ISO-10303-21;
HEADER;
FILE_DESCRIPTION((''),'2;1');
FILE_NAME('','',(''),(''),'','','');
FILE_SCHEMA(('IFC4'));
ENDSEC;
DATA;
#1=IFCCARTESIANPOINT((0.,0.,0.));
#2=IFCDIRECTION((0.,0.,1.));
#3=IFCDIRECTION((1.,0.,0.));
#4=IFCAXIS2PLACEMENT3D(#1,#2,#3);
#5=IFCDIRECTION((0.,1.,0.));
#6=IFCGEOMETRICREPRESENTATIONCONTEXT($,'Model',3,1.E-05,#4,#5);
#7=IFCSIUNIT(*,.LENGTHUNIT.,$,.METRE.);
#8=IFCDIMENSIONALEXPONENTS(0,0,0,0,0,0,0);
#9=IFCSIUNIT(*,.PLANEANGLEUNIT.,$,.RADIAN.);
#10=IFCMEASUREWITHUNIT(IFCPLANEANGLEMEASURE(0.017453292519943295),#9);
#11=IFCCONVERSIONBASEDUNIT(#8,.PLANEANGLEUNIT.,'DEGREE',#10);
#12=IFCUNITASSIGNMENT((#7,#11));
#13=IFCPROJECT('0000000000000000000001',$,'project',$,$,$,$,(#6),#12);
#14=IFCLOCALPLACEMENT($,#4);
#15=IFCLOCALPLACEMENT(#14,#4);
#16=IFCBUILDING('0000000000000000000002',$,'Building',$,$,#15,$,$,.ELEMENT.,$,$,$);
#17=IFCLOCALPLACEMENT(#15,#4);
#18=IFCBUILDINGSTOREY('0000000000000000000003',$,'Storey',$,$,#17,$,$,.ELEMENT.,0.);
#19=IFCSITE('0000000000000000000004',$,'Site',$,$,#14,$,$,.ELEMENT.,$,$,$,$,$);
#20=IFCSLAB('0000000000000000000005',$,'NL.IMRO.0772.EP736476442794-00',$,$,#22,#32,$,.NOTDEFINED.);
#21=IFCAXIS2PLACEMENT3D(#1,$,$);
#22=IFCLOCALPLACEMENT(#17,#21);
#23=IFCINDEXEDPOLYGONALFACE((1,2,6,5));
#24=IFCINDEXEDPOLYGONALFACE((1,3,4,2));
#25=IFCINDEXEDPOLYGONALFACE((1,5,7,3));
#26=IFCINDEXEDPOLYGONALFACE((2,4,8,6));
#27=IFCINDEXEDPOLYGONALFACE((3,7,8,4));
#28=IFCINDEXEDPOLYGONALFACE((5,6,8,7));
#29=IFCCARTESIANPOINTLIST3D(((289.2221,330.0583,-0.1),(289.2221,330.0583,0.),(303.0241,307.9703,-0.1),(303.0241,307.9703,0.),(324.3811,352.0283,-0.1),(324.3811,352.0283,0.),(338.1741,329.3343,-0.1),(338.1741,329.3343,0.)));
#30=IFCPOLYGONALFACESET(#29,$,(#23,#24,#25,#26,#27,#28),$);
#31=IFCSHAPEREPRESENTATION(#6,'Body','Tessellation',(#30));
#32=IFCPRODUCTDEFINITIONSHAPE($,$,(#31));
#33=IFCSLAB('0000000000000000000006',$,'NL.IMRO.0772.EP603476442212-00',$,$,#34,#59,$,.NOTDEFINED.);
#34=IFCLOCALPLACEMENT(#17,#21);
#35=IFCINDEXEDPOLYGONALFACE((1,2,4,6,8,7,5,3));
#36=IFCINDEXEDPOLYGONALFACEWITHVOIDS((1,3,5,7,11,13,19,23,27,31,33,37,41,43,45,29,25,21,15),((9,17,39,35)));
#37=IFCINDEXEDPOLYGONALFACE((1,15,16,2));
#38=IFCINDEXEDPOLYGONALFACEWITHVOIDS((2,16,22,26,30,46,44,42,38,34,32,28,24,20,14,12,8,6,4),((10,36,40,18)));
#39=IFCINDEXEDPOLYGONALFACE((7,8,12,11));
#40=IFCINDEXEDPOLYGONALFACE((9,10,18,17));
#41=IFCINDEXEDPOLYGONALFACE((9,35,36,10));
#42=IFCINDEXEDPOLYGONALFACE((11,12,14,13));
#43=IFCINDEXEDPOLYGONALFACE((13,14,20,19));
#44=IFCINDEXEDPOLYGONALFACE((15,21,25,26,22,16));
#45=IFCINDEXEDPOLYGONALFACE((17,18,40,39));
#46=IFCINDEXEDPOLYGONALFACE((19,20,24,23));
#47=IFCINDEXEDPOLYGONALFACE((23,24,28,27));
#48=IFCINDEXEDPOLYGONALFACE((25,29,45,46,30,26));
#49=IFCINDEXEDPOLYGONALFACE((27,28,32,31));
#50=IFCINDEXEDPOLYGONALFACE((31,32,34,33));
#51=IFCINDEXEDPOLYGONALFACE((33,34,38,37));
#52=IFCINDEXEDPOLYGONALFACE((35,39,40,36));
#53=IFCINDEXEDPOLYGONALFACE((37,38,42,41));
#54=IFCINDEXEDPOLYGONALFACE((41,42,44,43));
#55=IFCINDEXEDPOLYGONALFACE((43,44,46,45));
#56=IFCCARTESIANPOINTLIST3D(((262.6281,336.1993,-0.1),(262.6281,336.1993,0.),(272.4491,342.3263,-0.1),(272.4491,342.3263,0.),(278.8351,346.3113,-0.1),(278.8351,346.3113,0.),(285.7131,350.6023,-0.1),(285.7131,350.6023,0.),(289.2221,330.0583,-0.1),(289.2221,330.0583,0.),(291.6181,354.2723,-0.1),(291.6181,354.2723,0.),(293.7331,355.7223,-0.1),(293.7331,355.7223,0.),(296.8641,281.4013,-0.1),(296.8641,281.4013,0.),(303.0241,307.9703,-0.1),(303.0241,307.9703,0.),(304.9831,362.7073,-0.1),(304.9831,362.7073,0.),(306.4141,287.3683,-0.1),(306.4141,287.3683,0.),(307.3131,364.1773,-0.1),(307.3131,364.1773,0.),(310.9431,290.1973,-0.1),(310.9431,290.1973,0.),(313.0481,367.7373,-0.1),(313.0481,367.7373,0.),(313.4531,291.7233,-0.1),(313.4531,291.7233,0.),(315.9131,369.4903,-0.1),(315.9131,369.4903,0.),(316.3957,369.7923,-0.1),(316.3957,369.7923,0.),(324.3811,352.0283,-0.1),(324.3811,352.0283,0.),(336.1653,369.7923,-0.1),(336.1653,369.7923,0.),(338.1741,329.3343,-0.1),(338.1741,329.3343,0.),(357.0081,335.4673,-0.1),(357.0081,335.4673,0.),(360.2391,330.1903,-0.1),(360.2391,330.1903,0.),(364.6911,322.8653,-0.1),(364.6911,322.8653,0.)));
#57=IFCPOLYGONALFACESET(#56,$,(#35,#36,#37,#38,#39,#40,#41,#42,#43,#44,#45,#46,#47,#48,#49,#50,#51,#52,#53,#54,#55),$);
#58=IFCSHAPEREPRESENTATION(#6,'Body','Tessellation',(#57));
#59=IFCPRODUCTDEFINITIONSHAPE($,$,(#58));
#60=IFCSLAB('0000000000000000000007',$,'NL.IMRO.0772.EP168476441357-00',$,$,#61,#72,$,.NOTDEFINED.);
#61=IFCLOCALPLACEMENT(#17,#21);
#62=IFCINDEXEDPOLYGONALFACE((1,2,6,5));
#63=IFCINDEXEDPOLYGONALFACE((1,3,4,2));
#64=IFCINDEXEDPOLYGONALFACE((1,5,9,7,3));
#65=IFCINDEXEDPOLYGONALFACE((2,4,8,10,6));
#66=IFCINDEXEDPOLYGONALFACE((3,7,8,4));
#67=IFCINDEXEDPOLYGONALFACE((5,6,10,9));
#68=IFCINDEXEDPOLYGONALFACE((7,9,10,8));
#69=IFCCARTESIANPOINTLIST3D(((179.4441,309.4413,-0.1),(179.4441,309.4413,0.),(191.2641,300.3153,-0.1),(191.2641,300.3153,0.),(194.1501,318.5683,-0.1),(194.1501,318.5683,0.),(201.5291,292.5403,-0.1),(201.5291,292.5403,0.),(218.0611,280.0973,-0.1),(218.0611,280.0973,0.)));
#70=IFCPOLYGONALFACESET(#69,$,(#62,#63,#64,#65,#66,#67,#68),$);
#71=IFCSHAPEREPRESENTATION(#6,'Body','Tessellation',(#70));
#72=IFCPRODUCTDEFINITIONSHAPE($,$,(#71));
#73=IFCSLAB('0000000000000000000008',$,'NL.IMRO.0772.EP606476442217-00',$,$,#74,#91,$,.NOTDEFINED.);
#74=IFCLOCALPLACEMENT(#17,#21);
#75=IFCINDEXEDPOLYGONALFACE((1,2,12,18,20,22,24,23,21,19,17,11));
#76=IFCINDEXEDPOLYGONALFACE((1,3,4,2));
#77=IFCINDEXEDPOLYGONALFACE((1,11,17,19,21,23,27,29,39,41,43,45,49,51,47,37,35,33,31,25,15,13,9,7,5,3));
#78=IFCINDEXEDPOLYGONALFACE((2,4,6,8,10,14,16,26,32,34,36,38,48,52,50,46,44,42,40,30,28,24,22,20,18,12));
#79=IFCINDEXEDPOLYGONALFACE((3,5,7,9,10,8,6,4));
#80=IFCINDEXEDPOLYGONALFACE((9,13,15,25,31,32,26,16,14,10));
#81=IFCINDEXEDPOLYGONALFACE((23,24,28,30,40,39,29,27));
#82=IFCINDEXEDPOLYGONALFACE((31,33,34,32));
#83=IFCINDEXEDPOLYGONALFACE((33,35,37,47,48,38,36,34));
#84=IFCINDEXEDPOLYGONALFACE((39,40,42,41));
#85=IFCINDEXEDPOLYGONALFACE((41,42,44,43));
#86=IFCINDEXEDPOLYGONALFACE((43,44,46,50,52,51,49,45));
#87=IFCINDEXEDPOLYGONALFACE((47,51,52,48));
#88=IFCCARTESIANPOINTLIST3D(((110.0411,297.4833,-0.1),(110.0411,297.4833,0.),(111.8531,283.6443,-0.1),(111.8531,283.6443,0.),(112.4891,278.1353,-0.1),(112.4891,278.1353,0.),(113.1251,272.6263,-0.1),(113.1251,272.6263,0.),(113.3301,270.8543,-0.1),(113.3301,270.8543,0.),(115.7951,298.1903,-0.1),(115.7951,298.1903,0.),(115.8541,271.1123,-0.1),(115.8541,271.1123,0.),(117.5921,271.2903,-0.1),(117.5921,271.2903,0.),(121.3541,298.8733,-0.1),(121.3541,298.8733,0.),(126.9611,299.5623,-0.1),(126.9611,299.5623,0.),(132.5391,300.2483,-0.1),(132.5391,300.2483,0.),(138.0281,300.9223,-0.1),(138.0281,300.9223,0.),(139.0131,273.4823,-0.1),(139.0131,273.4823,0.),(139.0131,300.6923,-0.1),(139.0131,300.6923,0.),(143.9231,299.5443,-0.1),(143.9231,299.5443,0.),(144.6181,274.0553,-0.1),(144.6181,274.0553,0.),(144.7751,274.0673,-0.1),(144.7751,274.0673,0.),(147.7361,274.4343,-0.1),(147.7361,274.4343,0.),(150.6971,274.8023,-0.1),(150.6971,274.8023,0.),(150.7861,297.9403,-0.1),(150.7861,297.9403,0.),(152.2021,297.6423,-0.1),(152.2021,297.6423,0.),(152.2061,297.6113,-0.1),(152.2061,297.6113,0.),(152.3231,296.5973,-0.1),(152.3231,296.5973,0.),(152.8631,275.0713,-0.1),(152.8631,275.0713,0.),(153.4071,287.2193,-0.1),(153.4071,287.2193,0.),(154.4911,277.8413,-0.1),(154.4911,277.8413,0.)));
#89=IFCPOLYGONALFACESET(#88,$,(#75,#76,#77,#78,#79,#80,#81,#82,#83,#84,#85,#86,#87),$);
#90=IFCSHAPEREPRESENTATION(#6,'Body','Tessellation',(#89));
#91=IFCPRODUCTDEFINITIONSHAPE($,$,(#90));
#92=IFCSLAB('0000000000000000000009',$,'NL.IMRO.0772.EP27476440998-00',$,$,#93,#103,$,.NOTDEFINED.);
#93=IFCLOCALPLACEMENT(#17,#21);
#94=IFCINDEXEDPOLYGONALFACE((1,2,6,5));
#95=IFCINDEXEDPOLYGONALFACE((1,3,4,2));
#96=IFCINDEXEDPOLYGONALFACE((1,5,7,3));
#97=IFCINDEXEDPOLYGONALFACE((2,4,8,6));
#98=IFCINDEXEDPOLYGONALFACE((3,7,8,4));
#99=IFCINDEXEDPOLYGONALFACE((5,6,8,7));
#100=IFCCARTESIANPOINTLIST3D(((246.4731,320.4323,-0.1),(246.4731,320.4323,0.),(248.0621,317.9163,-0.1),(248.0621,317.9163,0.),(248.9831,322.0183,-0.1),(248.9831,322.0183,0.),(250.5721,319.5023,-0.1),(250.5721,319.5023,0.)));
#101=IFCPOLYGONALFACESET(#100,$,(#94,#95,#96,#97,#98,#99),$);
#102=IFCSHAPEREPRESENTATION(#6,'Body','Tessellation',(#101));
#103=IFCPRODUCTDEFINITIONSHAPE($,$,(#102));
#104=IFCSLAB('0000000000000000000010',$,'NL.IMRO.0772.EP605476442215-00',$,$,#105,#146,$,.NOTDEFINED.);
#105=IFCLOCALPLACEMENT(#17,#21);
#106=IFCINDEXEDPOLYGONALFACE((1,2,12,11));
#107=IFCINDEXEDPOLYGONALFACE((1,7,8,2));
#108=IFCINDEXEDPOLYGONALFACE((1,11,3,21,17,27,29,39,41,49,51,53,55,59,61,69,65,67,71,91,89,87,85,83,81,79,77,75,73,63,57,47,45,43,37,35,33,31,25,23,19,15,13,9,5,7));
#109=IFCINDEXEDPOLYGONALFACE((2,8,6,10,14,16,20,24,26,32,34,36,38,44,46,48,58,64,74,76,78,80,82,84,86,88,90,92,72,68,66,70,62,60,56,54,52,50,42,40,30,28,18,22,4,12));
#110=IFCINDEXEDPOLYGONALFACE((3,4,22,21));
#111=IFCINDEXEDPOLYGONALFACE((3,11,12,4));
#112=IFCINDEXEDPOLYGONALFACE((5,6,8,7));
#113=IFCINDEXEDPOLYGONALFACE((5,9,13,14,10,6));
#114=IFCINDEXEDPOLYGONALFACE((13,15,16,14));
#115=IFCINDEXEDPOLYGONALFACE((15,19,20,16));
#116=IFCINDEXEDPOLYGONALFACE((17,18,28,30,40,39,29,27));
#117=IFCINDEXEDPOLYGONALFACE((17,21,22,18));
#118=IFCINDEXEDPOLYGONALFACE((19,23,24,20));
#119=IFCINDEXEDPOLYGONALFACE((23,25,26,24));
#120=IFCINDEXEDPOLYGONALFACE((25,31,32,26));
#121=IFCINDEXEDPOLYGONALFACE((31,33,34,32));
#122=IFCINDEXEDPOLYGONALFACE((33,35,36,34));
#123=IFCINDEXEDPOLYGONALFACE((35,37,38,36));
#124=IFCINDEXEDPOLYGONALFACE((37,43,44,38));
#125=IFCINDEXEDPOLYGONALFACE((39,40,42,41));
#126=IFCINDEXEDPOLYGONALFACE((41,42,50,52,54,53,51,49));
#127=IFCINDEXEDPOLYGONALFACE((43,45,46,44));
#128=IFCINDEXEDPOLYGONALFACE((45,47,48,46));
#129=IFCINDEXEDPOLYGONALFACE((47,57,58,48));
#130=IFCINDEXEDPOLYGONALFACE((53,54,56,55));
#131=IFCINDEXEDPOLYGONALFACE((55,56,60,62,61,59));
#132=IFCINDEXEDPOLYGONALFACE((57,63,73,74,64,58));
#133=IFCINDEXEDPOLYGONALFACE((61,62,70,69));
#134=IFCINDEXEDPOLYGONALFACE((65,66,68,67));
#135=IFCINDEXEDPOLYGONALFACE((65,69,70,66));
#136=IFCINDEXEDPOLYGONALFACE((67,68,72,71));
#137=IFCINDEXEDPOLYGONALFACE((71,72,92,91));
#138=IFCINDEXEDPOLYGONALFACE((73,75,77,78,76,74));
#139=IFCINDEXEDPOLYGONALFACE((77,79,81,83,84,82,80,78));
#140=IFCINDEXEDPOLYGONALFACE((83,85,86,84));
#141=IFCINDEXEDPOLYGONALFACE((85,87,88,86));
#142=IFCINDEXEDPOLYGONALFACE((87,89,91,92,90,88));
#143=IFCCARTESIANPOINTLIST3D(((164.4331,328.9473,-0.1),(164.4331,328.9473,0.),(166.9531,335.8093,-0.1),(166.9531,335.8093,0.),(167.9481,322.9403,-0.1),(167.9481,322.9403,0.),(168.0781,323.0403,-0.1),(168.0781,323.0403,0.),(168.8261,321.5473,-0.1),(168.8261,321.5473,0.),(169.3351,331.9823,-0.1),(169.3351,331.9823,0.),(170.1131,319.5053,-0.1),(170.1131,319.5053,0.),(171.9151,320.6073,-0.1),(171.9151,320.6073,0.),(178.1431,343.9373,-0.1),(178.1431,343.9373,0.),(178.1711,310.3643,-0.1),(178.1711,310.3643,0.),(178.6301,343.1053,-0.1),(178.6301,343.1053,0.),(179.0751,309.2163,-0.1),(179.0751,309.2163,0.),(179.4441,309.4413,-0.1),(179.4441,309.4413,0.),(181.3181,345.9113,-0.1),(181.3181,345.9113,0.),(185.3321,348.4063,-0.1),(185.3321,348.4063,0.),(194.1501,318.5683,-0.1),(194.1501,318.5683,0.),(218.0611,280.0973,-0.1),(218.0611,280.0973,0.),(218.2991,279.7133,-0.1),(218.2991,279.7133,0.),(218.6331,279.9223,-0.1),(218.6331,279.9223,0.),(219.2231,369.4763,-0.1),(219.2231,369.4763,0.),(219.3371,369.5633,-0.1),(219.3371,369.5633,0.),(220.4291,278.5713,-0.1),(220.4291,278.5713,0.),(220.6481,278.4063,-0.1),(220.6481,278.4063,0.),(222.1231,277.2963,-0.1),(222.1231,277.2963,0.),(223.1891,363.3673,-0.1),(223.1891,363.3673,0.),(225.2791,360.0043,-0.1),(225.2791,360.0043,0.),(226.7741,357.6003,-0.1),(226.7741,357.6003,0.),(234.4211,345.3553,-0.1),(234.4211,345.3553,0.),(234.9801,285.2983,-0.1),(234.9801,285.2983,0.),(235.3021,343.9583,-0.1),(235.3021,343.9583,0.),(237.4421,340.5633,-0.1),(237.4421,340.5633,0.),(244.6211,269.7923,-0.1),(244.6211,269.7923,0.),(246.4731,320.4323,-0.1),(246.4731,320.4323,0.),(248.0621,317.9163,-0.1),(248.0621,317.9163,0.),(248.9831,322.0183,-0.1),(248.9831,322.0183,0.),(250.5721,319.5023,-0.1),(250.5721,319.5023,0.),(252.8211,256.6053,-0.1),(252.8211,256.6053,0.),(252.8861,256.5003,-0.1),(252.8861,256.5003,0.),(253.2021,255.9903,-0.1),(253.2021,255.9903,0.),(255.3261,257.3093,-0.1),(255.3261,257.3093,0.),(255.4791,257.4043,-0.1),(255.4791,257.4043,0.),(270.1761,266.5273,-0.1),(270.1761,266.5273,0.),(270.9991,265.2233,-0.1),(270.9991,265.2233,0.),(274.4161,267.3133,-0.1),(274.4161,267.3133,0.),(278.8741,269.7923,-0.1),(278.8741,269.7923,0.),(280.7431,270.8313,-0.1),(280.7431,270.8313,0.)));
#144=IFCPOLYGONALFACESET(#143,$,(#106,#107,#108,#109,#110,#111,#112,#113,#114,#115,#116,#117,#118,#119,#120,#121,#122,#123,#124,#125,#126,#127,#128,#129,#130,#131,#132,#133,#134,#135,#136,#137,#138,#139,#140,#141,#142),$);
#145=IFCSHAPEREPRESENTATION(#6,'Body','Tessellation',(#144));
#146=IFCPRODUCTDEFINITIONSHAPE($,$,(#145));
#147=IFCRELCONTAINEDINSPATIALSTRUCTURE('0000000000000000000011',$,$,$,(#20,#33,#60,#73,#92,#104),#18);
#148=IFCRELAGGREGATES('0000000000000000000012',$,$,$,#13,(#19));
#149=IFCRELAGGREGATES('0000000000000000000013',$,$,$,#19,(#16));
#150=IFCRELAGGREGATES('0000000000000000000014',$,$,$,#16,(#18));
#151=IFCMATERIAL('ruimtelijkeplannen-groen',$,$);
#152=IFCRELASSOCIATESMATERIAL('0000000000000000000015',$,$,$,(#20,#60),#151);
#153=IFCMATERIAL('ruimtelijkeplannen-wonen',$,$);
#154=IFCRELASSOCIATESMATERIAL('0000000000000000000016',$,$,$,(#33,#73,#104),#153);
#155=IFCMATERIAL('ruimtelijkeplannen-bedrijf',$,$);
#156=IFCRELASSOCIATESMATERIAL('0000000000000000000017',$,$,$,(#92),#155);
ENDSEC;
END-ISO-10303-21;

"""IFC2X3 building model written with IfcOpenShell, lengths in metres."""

from ifc_helpers import new_model, entity, si_unit, converted_unit, direction, frame, origin_with_axes, place, context, project, spatial, polyline, outline, extrude, material, element, save


model = new_model("IFC2X3")

# Units and contexts
model_context = context("Model", 3, precision=1e-05, world=origin_with_axes(), true_north=direction((0.0, 1.0, 0.0)))
ifc_project = project(units=[si_unit("LENGTHUNIT", "METRE"), converted_unit("PLANEANGLEUNIT", "DEGREE", entity("IfcPlaneAngleMeasure", 0.017453292519943295), si_unit("PLANEANGLEUNIT", "RADIAN"), dimensions=[0, 0, 0, 0, 0, 0, 0])], contexts=[model_context])

# Site, building, storey
site_placement = place(None, origin_with_axes())
site = spatial("IfcSite", under=ifc_project, at=site_placement, Name="Site", CompositionType="ELEMENT")
building_placement = place(site_placement, origin_with_axes())
building = spatial("IfcBuilding", under=site, at=building_placement, Name="Building", CompositionType="ELEMENT")
storey_placement = place(building_placement, origin_with_axes())
storey = spatial("IfcBuildingStorey", under=building, at=storey_placement, Name="Storey", CompositionType="ELEMENT", Elevation=0.0)

# Slabs
ifc_material_1 = material(Name="ruimtelijkeplannen-groen")
ifc_material_2 = material(Name="ruimtelijkeplannen-bedrijf")
slab_1_placement = place(storey_placement, frame((0.0, 0.0, -0.1), z_axis=(0.0, 0.0, 1.0), x_axis=(1.0, 0.0, 0.0)))
element("IfcSlab", 1, at=slab_1_placement, inside=storey, material=ifc_material_1, Name="NL.IMRO.0772.EP736476442794-00", PredefinedType="NOTDEFINED", context=model_context, shape_type="SweptSolid", body=[
    extrude(outline(polyline([(338.1741, 329.3343), (303.0241, 307.9703), (289.2221, 330.0583), (324.3811, 352.0283), (338.1741, 329.3343)])), origin_with_axes(), (0.0, 0.0, 1.0), 0.1),
])
ifc_material_3 = material(Name="ruimtelijkeplannen-wonen")
slab_2_placement = place(storey_placement, frame((0.0, 0.0, -0.1), z_axis=(0.0, 0.0, 1.0), x_axis=(1.0, 0.0, 0.0)))
element("IfcSlab", 2, at=slab_2_placement, inside=storey, material=ifc_material_3, Name="NL.IMRO.0772.EP603476442212-00", PredefinedType="NOTDEFINED", context=model_context, shape_type="SweptSolid", body=[
    extrude(outline(polyline([(357.0081, 335.4673), (360.2391, 330.1903), (364.6911, 322.8653), (313.4531, 291.7233), (310.9431, 290.1973), (306.4141, 287.3683), (296.8641, 281.4013), (262.6281, 336.1993), (272.4491, 342.3263), (278.8351, 346.3113), (285.7131, 350.6023), (291.6181, 354.2723), (293.7331, 355.7223), (304.9831, 362.7073), (307.3131, 364.1773), (313.0481, 367.7373), (315.9131, 369.4903), (316.3957, 369.7923), (336.1653, 369.7923), (357.0081, 335.4673)]), holes=[polyline([(303.0241, 307.9703), (338.1741, 329.3343), (324.3811, 352.0283), (289.2221, 330.0583), (303.0241, 307.9703)])]), origin_with_axes(), (0.0, 0.0, 1.0), 0.1),
])
slab_3_placement = place(storey_placement, frame((0.0, 0.0, -0.1), z_axis=(0.0, 0.0, 1.0), x_axis=(1.0, 0.0, 0.0)))
element("IfcSlab", 3, at=slab_3_placement, inside=storey, material=ifc_material_1, Name="NL.IMRO.0772.EP168476441357-00", PredefinedType="NOTDEFINED", context=model_context, shape_type="SweptSolid", body=[
    extrude(outline(polyline([(201.5291, 292.5403), (191.2641, 300.3153), (179.4441, 309.4413), (194.1501, 318.5683), (218.0611, 280.0973), (201.5291, 292.5403)])), origin_with_axes(), (0.0, 0.0, 1.0), 0.1),
])
slab_4_placement = place(storey_placement, frame((0.0, 0.0, -0.1), z_axis=(0.0, 0.0, 1.0), x_axis=(1.0, 0.0, 0.0)))
element("IfcSlab", 4, at=slab_4_placement, inside=storey, material=ifc_material_3, Name="NL.IMRO.0772.EP606476442217-00", PredefinedType="NOTDEFINED", context=model_context, shape_type="SweptSolid", body=[
    extrude(outline(polyline([(113.3301, 270.8543), (113.1251, 272.6263), (112.4891, 278.1353), (111.8531, 283.6443), (110.0411, 297.4833), (115.7951, 298.1903), (121.3541, 298.8733), (126.9611, 299.5623), (132.5391, 300.2483), (138.0281, 300.9223), (139.0131, 300.6923), (143.9231, 299.5443), (150.7861, 297.9403), (152.2021, 297.6423), (152.2061, 297.6113), (152.3231, 296.5973), (153.4071, 287.2193), (154.4911, 277.8413), (152.8631, 275.0713), (150.6971, 274.8023), (147.7361, 274.4343), (144.7751, 274.0673), (144.6181, 274.0553), (139.0131, 273.4823), (117.5921, 271.2903), (115.8541, 271.1123), (113.3301, 270.8543)])), origin_with_axes(), (0.0, 0.0, 1.0), 0.1),
])
slab_5_placement = place(storey_placement, frame((0.0, 0.0, -0.1), z_axis=(0.0, 0.0, 1.0), x_axis=(1.0, 0.0, 0.0)))
element("IfcSlab", 5, at=slab_5_placement, inside=storey, material=ifc_material_2, Name="NL.IMRO.0772.EP27476440998-00", PredefinedType="NOTDEFINED", context=model_context, shape_type="SweptSolid", body=[
    extrude(outline(polyline([(248.0621, 317.9163), (246.4731, 320.4323), (248.9831, 322.0183), (250.5721, 319.5023), (248.0621, 317.9163)])), origin_with_axes(), (0.0, 0.0, 1.0), 0.1),
])
slab_6_placement = place(storey_placement, frame((0.0, 0.0, -0.1), z_axis=(0.0, 0.0, 1.0), x_axis=(1.0, 0.0, 0.0)))
element("IfcSlab", 6, at=slab_6_placement, inside=storey, material=ifc_material_3, Name="NL.IMRO.0772.EP605476442215-00", PredefinedType="NOTDEFINED", context=model_context, shape_type="SweptSolid", body=[
    extrude(outline(polyline([(248.0621, 317.9163), (250.5721, 319.5023), (280.7431, 270.8313), (278.8741, 269.7923), (274.4161, 267.3133), (270.9991, 265.2233), (270.1761, 266.5273), (255.4791, 257.4043), (255.3261, 257.3093), (253.2021, 255.9903), (252.8861, 256.5003), (252.8211, 256.6053), (244.6211, 269.7923), (234.9801, 285.2983), (222.1231, 277.2963), (220.6481, 278.4063), (220.4291, 278.5713), (218.6331, 279.9223), (218.2991, 279.7133), (218.0611, 280.0973), (194.1501, 318.5683), (179.4441, 309.4413), (179.0751, 309.2163), (178.1711, 310.3643), (171.9151, 320.6073), (170.1131, 319.5053), (168.8261, 321.5473), (167.9481, 322.9403), (168.0781, 323.0403), (164.4331, 328.9473), (169.3351, 331.9823), (166.9531, 335.8093), (178.6301, 343.1053), (178.1431, 343.9373), (181.3181, 345.9113), (185.3321, 348.4063), (219.2231, 369.4763), (219.3371, 369.5633), (223.1891, 363.3673), (225.2791, 360.0043), (226.7741, 357.6003), (234.4211, 345.3553), (235.3021, 343.9583), (237.4421, 340.5633), (248.9831, 322.0183), (246.4731, 320.4323), (248.0621, 317.9163)])), origin_with_axes(), (0.0, 0.0, 1.0), 0.1),
])

save(model, "model.ifc")
